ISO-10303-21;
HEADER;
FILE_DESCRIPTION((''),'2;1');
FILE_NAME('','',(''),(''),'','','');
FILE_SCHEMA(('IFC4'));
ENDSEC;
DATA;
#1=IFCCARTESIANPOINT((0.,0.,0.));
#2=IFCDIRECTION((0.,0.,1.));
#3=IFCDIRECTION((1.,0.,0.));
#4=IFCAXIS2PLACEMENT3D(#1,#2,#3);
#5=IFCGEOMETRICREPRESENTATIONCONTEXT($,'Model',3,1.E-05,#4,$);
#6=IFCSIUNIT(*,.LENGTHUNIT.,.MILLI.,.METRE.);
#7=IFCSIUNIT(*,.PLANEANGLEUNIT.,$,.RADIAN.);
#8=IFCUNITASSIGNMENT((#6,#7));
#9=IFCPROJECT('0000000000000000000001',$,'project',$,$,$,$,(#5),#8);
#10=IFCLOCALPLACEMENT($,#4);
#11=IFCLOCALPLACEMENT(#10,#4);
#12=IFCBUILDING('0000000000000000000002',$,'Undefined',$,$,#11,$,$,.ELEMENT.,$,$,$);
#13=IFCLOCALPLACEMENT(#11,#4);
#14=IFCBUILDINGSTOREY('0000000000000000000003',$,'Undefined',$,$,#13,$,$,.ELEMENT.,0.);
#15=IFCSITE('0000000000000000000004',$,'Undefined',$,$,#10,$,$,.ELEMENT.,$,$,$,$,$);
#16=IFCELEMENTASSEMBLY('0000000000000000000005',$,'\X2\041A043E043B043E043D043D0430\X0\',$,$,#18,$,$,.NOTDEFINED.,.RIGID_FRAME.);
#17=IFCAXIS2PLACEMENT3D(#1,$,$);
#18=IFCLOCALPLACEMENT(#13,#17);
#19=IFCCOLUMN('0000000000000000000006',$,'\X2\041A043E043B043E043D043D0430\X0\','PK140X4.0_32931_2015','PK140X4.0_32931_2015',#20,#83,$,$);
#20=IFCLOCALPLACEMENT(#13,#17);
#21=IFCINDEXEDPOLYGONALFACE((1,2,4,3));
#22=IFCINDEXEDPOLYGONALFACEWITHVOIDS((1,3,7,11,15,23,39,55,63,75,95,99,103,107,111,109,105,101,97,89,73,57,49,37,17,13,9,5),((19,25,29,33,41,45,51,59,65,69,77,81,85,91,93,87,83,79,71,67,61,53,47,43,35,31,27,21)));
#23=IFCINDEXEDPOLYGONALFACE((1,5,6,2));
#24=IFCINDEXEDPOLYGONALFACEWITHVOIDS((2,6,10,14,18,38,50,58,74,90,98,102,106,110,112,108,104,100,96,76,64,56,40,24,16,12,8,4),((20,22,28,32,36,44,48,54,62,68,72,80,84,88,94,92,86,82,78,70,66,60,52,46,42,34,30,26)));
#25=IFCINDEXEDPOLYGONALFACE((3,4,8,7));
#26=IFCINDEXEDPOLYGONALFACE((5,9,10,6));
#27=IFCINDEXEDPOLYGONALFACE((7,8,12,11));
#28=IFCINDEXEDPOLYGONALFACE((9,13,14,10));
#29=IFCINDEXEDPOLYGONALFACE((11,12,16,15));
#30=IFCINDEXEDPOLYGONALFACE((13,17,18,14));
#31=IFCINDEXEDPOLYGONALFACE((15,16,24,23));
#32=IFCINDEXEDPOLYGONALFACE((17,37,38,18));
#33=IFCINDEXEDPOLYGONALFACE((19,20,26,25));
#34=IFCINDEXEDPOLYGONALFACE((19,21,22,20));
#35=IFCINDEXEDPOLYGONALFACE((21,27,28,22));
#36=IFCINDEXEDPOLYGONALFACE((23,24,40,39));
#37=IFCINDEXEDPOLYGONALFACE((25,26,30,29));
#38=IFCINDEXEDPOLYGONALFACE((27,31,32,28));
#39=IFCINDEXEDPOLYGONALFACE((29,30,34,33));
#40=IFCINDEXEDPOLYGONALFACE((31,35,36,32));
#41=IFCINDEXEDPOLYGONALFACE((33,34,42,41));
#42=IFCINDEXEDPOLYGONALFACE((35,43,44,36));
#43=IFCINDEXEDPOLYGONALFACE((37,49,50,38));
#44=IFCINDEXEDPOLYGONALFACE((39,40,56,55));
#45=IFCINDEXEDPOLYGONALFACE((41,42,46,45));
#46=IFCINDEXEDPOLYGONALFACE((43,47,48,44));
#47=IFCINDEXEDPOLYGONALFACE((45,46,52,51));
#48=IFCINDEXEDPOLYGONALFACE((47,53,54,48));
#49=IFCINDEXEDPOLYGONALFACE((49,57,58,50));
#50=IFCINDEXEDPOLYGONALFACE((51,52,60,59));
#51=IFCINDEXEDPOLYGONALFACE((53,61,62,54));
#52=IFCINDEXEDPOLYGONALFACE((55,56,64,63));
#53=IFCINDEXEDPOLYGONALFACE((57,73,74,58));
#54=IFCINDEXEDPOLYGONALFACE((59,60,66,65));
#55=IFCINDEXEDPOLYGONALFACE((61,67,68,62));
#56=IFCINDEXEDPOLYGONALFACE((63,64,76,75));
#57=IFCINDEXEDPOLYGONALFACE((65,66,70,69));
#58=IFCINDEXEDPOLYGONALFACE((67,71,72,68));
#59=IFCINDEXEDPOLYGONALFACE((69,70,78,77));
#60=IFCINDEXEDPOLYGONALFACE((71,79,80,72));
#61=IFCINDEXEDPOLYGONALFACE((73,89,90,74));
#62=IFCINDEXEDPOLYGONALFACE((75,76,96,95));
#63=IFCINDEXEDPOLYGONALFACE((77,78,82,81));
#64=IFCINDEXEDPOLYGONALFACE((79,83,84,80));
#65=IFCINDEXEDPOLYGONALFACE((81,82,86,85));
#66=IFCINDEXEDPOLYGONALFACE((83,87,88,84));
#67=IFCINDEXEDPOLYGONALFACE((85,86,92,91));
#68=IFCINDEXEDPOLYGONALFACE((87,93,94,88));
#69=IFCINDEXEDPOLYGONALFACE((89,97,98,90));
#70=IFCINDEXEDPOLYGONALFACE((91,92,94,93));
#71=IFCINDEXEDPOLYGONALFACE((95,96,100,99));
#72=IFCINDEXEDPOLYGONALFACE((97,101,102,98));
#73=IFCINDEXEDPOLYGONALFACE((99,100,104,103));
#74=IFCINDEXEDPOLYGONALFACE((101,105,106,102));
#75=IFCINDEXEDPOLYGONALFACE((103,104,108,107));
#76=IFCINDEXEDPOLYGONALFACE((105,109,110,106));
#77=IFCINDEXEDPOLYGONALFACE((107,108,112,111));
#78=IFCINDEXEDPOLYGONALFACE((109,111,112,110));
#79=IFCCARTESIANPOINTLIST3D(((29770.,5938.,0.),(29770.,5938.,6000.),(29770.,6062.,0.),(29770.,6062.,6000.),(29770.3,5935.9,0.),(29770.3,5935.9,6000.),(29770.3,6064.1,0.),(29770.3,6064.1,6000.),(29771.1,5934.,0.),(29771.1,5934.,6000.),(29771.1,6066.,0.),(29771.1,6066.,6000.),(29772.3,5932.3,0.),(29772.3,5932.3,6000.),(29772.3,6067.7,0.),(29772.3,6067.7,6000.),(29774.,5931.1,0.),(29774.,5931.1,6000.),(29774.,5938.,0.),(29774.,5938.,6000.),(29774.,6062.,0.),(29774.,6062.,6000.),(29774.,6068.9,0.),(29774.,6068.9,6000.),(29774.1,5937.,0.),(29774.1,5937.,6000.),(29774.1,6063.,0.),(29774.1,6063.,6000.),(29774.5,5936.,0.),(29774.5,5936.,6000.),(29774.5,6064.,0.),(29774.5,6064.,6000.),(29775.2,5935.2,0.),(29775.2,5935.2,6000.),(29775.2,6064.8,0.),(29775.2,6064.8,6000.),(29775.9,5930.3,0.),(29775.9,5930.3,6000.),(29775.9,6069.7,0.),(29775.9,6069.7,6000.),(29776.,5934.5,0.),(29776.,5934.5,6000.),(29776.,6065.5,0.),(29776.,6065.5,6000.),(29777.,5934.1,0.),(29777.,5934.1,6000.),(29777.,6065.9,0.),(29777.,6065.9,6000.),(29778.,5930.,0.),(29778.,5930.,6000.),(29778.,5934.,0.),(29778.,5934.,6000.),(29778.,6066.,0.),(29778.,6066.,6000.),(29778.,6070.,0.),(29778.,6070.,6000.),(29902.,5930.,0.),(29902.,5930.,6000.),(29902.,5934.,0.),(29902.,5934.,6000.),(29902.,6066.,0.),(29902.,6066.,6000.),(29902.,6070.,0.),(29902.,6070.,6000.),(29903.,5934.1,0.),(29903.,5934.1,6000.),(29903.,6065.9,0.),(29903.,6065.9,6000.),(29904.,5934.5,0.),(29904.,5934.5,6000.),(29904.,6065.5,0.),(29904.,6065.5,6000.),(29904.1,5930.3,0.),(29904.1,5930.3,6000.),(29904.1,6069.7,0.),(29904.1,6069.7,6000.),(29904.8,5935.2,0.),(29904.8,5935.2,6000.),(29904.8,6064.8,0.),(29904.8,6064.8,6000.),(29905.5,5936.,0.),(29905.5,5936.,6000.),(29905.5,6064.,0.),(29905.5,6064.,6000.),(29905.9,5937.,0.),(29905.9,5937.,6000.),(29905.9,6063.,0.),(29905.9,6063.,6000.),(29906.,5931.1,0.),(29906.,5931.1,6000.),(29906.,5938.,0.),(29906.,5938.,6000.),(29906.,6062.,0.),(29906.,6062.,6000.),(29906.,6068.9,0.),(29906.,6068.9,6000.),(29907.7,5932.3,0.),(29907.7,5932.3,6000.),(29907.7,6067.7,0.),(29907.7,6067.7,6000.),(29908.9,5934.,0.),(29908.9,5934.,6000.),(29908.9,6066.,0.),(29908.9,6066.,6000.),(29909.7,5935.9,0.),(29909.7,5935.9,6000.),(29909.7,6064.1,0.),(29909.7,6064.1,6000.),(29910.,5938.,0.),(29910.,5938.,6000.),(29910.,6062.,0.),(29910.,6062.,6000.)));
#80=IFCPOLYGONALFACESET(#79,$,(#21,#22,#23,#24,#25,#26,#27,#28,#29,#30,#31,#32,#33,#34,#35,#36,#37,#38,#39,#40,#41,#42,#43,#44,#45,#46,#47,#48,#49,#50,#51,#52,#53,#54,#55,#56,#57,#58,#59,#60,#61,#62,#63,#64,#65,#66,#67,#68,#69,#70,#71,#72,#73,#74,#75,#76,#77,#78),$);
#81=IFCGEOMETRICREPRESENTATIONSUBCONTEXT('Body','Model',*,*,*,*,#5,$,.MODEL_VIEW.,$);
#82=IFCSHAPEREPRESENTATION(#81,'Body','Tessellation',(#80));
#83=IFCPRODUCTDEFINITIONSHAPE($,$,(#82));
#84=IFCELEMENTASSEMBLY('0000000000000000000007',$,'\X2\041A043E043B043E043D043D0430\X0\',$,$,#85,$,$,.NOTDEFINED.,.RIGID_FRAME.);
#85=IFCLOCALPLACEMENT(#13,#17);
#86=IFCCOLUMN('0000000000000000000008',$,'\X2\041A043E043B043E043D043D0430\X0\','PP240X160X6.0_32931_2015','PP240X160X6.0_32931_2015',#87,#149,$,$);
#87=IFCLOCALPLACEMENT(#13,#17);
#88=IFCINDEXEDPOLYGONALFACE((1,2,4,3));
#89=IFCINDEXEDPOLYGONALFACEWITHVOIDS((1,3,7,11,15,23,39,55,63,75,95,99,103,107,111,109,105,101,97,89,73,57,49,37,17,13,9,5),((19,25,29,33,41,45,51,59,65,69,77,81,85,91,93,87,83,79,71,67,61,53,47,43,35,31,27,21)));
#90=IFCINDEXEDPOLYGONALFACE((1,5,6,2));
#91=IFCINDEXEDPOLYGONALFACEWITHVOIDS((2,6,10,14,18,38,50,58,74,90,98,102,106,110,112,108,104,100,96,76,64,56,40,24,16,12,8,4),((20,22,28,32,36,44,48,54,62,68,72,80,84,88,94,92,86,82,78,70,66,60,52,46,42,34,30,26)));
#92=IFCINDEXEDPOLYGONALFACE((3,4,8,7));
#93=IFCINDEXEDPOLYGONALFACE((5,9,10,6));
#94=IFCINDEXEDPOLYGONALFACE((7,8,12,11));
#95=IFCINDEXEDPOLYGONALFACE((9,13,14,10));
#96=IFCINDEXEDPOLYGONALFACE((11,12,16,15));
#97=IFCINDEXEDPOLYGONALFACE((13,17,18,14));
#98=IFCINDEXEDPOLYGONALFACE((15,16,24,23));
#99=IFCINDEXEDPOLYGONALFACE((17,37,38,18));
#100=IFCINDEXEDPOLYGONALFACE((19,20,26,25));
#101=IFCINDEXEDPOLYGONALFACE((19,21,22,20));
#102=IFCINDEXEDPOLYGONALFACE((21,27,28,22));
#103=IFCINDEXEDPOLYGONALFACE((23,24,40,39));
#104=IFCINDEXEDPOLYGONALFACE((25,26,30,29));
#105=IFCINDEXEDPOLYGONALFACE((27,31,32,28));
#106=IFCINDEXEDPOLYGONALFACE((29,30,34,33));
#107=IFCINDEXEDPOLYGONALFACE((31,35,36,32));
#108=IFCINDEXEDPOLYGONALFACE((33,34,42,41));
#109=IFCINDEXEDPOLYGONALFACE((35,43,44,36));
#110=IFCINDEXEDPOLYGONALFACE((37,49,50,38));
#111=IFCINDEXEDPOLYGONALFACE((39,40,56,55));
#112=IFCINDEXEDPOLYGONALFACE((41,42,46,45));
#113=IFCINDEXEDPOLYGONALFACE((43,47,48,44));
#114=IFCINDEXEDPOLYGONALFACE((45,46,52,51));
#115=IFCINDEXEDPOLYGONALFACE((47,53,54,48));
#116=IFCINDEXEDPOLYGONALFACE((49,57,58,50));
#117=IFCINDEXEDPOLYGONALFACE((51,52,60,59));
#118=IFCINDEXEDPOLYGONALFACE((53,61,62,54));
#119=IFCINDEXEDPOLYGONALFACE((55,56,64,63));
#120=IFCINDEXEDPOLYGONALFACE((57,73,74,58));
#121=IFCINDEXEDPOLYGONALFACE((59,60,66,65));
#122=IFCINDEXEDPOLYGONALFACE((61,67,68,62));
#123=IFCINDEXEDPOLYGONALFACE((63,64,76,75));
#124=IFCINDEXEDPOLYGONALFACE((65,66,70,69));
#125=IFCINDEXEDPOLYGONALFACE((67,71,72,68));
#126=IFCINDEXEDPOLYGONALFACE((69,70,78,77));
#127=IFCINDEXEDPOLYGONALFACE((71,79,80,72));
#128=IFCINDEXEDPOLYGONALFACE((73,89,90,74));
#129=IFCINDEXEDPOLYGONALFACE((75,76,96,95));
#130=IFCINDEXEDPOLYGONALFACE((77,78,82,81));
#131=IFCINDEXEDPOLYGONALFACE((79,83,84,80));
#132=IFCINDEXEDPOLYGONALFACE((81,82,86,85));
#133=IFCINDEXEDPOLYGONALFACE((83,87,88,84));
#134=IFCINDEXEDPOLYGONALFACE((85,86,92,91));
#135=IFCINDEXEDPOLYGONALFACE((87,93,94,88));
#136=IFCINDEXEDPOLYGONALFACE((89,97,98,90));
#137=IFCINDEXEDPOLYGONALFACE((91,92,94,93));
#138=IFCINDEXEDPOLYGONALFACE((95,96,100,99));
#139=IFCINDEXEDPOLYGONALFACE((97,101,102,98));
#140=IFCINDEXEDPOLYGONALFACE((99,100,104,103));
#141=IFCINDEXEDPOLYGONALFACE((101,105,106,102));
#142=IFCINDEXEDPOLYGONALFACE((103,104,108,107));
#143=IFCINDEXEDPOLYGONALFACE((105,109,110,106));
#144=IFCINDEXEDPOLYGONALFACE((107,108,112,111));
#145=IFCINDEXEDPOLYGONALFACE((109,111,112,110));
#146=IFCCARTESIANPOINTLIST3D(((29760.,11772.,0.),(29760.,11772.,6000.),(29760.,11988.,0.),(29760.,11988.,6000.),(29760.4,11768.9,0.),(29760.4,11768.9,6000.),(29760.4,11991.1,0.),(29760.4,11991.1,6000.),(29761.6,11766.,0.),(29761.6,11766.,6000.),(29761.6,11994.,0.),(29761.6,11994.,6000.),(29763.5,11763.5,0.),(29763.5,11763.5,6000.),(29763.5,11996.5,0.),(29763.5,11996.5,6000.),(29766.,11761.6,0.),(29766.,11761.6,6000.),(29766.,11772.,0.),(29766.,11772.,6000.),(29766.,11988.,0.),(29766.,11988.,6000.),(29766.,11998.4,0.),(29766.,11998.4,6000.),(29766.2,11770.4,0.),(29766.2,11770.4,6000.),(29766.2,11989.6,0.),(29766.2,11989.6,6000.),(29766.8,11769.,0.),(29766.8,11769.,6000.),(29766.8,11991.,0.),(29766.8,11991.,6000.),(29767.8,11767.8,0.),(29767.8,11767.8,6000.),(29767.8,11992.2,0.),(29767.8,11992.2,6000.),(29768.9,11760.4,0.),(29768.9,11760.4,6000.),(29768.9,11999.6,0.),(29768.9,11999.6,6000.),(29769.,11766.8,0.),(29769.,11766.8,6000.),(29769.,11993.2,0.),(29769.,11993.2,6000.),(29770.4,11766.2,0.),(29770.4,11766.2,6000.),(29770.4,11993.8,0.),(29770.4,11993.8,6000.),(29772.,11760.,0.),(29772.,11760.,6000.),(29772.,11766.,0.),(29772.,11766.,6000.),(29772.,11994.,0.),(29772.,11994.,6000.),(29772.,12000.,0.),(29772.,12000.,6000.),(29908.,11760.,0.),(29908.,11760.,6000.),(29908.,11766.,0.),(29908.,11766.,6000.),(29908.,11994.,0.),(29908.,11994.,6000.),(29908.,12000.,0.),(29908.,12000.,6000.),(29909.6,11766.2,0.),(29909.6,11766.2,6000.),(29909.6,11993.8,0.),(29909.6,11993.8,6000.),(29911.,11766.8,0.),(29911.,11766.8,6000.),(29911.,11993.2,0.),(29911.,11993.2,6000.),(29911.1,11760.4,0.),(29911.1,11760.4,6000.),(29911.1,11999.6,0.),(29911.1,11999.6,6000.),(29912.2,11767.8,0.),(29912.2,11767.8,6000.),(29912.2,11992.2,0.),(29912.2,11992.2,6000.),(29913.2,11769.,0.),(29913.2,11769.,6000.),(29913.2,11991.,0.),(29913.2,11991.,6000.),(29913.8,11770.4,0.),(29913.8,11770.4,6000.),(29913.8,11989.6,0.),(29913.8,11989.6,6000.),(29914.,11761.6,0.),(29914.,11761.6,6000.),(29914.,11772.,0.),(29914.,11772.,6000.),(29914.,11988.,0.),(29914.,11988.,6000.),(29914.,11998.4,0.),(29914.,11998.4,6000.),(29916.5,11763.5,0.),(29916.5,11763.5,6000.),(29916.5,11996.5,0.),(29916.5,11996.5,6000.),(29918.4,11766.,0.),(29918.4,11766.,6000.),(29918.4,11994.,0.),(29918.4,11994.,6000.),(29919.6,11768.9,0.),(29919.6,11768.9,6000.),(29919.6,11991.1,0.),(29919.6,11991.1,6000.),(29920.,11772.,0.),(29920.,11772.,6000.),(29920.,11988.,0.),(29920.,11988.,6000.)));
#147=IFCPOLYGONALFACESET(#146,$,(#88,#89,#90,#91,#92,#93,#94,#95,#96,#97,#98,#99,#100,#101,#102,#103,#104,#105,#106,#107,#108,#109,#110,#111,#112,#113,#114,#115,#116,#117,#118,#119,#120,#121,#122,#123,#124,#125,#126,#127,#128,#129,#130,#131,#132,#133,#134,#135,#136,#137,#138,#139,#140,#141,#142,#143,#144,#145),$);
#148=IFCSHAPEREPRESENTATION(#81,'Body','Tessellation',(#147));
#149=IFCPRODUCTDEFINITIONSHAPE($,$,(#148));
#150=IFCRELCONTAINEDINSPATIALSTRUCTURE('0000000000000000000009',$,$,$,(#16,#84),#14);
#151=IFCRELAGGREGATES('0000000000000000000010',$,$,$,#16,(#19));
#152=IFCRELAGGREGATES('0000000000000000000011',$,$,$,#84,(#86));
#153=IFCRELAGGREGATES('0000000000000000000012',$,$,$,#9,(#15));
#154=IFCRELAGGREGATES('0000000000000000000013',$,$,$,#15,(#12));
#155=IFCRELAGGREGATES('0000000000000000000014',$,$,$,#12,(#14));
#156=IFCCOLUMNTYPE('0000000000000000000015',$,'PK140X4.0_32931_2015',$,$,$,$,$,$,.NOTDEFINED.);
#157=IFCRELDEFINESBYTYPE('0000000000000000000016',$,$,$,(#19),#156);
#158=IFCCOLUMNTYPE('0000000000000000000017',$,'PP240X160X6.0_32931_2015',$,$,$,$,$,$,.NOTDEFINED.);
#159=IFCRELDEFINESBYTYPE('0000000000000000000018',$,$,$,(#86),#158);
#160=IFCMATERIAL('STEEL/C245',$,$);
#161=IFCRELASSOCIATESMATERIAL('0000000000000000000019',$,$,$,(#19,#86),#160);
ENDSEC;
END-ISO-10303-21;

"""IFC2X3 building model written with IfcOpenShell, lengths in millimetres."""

from ifc_helpers import new_model, si_unit, frame, origin_with_axes, origin_2d_with_axis, place, context, subcontext, project, spatial, hollow_rectangle, extrude, material, type_object, element, aggregate, save


model = new_model("IFC2X3")

# Units and contexts
model_context = context("Model", 3, precision=1e-05, world=origin_with_axes())
body_context = subcontext(model_context, "Body", "Model", "MODEL_VIEW")
ifc_project = project(units=[si_unit("LENGTHUNIT", "METRE", prefix="MILLI"), si_unit("PLANEANGLEUNIT", "RADIAN")], contexts=[model_context])

# Site, building, storey
site_placement = place(None, origin_with_axes())
site = spatial("IfcSite", under=ifc_project, at=site_placement, Name="Undefined", CompositionType="ELEMENT")
building_placement = place(site_placement, origin_with_axes())
building = spatial("IfcBuilding", under=site, at=building_placement, Name="Undefined", CompositionType="ELEMENT")
storey_placement = place(building_placement, origin_with_axes())
storey = spatial("IfcBuildingStorey", under=building, at=storey_placement, Name="Undefined", CompositionType="ELEMENT", Elevation=0.0)

# Element assemblies, columns
assembly_1_placement = place(storey_placement, origin_with_axes())
assembly_1 = element("IfcElementAssembly", 1, at=assembly_1_placement, inside=storey, Name="Колонна", AssemblyPlace="NOTDEFINED", PredefinedType="RIGID_FRAME")
ifc_material = material(Name="STEEL/C245")
column_type_1 = type_object("IfcColumnType", Name="PK140X4.0_32931_2015", PredefinedType="NOTDEFINED")
column_1_placement = place(assembly_1_placement, frame((29840.0, 6000.0, 0.0), z_axis=(0.0, 0.0, 1.0), x_axis=(0.0, 1.0, 0.0)))
column_1 = element("IfcColumn", 2, at=column_1_placement, type_object=column_type_1, material=ifc_material, Name="Колонна", Description="PK140X4.0_32931_2015", ObjectType="PK140X4.0_32931_2015", context=body_context, shape_type="SweptSolid", body=[
    extrude(hollow_rectangle(XDim=140.0, YDim=140.0, WallThickness=4.0, InnerFilletRadius=4.0, OuterFilletRadius=8.0, at=origin_2d_with_axis()), frame((0.0, 0.0, 6000.0), z_axis=(0.0, 0.0, -1.0), x_axis=(0.0, 1.0, 0.0)), (0.0, 0.0, 1.0), 6000.0),
])
aggregate(assembly_1, [column_1])
assembly_2_placement = place(storey_placement, origin_with_axes())
assembly_2 = element("IfcElementAssembly", 3, at=assembly_2_placement, inside=storey, Name="Колонна", AssemblyPlace="NOTDEFINED", PredefinedType="RIGID_FRAME")
column_type_2 = type_object("IfcColumnType", Name="PP240X160X6.0_32931_2015", PredefinedType="NOTDEFINED")
column_2_placement = place(assembly_2_placement, frame((29840.0, 11880.0, 0.0), z_axis=(0.0, 0.0, 1.0), x_axis=(0.0, -1.0, 0.0)))
column_2 = element("IfcColumn", 4, at=column_2_placement, type_object=column_type_2, material=ifc_material, Name="Колонна", Description="PP240X160X6.0_32931_2015", ObjectType="PP240X160X6.0_32931_2015", context=body_context, shape_type="SweptSolid", body=[
    extrude(hollow_rectangle(XDim=160.0, YDim=240.0, WallThickness=6.0, InnerFilletRadius=6.0, OuterFilletRadius=12.0, at=origin_2d_with_axis()), frame((0.0, 0.0, 6000.0), z_axis=(0.0, 0.0, -1.0), x_axis=(0.0, 1.0, 0.0)), (0.0, 0.0, 1.0), 6000.0),
])
aggregate(assembly_2, [column_2])

save(model, "model.ifc")
